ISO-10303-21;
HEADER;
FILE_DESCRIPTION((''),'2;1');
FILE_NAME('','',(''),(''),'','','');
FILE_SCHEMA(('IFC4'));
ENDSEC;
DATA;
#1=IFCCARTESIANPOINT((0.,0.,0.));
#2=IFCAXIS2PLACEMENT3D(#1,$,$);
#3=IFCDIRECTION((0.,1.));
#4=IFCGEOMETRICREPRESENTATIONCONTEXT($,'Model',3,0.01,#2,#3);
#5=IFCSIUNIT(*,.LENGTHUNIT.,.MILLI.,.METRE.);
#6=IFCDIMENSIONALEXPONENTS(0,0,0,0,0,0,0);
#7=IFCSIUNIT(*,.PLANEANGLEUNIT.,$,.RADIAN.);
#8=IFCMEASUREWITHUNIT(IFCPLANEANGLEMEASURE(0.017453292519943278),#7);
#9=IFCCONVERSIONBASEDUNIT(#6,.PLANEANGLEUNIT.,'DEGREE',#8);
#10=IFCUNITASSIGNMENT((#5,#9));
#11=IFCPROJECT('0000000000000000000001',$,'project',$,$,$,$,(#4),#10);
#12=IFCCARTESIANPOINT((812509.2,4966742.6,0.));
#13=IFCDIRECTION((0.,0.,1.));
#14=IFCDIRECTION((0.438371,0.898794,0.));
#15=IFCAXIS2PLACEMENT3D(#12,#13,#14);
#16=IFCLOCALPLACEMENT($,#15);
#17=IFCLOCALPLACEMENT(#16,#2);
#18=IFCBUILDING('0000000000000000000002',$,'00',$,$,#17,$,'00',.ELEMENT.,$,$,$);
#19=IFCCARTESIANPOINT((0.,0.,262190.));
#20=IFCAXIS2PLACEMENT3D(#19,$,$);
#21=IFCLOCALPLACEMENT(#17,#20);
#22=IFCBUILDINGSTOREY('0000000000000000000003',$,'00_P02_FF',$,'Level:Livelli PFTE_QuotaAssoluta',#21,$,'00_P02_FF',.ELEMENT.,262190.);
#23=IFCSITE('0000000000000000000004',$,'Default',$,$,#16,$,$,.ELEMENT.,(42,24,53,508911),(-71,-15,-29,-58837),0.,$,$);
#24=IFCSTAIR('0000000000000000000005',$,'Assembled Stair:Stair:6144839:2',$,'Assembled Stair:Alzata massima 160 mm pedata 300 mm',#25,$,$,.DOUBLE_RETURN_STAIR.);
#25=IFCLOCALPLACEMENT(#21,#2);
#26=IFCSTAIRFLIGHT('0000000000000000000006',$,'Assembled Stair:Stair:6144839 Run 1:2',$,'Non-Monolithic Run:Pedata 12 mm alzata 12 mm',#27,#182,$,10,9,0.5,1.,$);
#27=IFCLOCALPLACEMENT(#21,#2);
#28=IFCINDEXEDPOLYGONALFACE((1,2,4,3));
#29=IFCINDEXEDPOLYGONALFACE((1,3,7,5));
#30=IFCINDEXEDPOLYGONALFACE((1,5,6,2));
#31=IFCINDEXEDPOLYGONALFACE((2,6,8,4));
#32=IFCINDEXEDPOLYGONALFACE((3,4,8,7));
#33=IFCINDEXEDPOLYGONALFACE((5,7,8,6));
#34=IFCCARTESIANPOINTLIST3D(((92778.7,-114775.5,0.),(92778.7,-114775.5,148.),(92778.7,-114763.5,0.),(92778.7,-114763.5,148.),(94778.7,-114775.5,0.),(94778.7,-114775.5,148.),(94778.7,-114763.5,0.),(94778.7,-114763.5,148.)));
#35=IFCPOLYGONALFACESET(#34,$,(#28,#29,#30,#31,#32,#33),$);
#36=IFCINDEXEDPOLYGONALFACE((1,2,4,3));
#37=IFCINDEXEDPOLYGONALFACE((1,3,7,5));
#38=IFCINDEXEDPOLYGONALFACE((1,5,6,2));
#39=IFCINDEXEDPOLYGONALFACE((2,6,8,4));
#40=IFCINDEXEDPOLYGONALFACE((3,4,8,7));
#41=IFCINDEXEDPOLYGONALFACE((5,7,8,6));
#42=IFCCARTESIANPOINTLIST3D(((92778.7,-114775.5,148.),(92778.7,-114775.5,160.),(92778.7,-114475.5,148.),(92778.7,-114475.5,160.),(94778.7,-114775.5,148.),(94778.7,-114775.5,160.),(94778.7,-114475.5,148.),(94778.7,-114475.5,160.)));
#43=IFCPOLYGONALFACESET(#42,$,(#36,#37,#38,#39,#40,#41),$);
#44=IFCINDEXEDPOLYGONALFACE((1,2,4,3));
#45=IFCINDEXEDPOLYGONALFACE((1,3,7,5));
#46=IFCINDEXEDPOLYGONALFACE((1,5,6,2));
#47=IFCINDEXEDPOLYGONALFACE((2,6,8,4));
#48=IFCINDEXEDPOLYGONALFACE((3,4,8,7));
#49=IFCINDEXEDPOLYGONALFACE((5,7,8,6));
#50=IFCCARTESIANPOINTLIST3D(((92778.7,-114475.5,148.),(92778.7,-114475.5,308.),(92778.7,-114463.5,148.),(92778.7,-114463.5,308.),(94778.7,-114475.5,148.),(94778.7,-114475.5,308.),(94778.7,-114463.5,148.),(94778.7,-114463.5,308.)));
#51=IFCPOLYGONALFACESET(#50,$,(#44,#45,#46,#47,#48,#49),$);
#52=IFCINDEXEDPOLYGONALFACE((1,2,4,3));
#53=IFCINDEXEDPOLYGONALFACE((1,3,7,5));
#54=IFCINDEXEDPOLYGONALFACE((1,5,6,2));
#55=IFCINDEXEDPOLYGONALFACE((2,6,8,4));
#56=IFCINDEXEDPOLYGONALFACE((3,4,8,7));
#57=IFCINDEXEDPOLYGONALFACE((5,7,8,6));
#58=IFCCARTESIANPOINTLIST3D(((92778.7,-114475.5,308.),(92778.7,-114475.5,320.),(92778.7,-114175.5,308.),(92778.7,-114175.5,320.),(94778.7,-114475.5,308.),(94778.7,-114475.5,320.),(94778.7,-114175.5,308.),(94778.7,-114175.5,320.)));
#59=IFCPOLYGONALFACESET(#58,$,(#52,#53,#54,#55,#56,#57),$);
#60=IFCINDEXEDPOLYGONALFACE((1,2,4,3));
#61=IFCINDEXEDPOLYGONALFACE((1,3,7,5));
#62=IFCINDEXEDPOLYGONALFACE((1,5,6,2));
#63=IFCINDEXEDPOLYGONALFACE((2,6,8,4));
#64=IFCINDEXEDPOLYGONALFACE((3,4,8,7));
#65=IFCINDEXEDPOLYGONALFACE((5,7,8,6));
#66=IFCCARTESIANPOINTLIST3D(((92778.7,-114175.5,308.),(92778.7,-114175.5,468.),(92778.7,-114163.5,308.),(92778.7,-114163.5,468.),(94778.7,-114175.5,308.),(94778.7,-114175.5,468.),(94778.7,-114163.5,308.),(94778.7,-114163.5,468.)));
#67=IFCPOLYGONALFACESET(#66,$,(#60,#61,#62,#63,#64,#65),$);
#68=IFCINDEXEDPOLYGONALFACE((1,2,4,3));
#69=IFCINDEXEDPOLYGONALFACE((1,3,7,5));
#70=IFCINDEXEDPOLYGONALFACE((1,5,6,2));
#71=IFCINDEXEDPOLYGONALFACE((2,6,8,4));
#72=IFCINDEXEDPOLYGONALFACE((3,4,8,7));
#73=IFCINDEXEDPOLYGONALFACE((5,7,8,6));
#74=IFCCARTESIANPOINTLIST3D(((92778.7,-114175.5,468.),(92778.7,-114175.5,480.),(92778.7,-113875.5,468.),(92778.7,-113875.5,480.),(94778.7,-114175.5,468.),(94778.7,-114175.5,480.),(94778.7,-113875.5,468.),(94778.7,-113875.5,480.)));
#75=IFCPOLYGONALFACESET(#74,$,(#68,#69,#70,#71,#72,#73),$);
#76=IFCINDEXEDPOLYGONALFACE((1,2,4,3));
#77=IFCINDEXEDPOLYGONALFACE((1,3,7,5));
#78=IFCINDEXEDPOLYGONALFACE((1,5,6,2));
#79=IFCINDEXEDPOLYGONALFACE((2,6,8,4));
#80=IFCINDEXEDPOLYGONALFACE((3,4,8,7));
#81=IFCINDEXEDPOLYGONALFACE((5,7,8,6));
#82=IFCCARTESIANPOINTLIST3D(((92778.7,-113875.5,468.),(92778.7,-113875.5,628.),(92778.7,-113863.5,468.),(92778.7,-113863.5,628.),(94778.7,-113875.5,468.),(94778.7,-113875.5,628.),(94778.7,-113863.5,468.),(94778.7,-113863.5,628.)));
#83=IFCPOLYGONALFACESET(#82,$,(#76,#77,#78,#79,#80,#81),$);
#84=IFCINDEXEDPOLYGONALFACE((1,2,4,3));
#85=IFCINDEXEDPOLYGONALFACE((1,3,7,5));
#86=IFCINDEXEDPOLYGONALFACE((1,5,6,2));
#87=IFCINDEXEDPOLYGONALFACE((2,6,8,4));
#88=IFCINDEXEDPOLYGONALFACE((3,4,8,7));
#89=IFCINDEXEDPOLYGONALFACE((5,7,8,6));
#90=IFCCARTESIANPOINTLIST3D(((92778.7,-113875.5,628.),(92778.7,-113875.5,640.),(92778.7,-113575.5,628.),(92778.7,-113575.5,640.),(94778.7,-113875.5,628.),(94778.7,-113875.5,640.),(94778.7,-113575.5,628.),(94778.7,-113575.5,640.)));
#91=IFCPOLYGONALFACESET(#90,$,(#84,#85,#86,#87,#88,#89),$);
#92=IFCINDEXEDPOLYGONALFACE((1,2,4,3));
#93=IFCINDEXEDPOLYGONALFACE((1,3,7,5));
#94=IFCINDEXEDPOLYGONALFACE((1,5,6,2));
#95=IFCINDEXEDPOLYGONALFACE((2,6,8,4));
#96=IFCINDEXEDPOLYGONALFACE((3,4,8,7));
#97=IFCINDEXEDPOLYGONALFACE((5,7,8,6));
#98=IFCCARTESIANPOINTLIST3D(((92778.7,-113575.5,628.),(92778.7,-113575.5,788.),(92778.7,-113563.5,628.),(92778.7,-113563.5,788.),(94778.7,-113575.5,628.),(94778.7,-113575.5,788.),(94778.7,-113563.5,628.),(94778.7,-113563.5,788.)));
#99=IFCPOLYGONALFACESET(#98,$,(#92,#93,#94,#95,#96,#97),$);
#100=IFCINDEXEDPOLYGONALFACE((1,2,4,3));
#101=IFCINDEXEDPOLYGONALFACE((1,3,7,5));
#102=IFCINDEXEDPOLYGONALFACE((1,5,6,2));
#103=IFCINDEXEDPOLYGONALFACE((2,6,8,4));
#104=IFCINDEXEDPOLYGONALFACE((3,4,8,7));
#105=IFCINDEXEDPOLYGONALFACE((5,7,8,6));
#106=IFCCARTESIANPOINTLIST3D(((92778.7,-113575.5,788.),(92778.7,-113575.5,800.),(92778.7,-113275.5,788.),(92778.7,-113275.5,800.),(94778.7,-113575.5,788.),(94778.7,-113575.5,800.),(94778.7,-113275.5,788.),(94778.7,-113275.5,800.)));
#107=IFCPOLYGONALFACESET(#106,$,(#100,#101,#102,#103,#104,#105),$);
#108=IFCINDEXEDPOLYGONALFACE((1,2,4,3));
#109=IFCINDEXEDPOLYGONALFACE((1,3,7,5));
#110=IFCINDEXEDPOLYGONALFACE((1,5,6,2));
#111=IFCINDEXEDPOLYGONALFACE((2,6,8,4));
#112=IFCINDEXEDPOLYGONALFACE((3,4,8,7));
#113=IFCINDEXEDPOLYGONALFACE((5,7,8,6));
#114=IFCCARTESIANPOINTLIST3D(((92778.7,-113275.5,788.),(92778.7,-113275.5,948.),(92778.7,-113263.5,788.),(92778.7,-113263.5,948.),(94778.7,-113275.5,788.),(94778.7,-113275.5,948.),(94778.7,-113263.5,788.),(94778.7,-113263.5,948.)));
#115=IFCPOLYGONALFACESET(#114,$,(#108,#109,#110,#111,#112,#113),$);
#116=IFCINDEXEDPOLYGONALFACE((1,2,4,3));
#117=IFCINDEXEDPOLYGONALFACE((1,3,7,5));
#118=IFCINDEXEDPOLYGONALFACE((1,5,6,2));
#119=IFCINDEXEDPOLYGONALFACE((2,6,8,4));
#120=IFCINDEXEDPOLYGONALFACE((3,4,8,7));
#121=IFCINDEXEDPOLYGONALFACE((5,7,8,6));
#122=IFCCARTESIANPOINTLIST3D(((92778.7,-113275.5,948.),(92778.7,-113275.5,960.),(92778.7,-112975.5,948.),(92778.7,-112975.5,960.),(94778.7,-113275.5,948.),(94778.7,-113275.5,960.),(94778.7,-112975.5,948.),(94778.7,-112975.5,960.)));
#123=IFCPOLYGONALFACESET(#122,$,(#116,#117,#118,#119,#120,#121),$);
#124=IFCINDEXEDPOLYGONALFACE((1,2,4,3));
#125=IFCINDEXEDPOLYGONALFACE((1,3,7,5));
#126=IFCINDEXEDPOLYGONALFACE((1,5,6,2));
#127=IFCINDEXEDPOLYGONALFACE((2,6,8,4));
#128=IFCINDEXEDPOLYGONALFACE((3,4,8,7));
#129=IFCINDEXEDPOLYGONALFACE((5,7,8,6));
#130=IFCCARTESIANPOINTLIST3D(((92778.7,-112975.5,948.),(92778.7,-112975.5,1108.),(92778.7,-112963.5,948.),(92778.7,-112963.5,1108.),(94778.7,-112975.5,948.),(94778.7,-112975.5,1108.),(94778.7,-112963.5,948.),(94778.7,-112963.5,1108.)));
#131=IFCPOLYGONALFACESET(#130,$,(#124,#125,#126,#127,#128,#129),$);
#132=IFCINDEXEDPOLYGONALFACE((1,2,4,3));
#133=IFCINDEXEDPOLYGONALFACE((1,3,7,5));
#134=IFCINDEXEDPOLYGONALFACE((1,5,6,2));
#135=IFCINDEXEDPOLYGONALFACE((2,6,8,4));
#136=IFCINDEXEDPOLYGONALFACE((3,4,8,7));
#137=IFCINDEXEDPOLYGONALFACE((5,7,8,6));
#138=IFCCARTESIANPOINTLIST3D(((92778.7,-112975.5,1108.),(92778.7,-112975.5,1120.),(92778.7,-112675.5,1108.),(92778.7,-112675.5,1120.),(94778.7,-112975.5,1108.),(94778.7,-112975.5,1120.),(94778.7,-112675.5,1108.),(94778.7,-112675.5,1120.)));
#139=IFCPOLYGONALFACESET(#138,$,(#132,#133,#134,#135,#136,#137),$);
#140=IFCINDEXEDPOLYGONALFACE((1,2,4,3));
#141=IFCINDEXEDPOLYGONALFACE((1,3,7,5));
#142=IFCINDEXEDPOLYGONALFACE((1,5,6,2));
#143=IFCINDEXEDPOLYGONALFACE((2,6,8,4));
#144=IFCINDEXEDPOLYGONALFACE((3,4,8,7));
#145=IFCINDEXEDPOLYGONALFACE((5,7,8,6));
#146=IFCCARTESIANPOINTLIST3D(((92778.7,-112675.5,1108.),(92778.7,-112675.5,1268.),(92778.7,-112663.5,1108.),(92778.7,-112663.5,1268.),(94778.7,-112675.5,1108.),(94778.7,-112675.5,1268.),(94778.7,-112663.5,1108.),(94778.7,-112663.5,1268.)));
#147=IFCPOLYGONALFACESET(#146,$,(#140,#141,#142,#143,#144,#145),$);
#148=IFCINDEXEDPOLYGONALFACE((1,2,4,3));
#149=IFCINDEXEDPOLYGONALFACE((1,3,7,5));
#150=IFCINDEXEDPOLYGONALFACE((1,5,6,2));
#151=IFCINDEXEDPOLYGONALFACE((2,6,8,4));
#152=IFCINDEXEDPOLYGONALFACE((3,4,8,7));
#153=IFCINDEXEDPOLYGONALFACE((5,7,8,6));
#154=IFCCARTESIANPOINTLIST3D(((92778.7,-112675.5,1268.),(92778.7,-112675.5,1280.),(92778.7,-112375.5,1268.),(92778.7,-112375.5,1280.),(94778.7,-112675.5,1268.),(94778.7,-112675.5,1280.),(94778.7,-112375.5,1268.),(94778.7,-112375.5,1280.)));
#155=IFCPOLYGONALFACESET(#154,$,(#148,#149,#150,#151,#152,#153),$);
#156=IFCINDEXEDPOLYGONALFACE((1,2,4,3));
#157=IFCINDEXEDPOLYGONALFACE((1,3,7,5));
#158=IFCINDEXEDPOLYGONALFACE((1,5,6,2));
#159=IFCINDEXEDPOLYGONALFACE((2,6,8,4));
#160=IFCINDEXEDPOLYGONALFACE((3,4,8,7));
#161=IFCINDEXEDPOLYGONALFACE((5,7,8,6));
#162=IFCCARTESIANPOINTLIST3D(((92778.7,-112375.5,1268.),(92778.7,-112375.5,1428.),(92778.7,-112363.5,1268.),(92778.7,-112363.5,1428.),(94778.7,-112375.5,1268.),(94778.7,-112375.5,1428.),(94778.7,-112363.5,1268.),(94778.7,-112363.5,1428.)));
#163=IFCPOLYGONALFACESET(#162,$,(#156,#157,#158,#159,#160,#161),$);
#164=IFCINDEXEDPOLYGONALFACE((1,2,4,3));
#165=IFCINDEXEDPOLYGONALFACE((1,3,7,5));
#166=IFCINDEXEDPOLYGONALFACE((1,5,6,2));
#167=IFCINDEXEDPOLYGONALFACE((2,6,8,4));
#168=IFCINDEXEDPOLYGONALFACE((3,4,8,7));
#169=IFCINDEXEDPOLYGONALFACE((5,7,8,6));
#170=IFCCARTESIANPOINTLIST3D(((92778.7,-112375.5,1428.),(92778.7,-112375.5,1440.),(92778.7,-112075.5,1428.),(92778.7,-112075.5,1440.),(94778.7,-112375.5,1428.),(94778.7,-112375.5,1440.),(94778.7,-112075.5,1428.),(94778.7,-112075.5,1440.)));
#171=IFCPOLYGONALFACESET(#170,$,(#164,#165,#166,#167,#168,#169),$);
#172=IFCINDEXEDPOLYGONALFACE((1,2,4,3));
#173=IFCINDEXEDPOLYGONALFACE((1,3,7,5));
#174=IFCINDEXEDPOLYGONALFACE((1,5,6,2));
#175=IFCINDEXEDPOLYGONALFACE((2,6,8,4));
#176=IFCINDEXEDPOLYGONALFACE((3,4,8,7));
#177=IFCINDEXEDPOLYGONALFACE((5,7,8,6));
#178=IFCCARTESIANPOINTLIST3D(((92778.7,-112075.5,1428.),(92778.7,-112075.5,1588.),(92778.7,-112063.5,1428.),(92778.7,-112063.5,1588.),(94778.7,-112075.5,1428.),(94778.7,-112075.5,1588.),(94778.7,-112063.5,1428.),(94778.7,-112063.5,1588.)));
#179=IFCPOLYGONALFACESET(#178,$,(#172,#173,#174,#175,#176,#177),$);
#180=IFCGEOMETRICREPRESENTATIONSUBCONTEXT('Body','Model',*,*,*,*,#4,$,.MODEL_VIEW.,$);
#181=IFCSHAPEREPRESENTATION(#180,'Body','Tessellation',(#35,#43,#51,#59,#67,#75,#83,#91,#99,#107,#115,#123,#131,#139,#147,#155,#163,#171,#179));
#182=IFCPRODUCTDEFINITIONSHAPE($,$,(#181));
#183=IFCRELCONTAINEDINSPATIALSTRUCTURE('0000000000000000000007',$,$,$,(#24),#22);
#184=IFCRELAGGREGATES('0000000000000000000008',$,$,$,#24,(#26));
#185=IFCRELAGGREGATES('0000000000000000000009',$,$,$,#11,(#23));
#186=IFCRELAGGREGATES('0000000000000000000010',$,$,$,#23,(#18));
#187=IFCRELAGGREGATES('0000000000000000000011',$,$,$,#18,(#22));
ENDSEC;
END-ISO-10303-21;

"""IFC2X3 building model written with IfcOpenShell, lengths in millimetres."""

from ifc_helpers import new_model, entity, si_unit, converted_unit, direction, frame, frame_2d, origin, origin_2d_with_axis, place, context, subcontext, project, spatial, rectangle, extrude, element, aggregate, save


model = new_model("IFC2X3")

# Units and contexts
model_context = context("Model", 3, precision=0.01, world=origin(), true_north=direction((0.0, 1.0)))
body_context = subcontext(model_context, "Body", "Model", "MODEL_VIEW")
ifc_project = project(units=[si_unit("LENGTHUNIT", "METRE", prefix="MILLI"), converted_unit("PLANEANGLEUNIT", "DEGREE", entity("IfcPlaneAngleMeasure", 0.017453292519943278), si_unit("PLANEANGLEUNIT", "RADIAN"), dimensions=[0, 0, 0, 0, 0, 0, 0])], contexts=[model_context])

# Site, building, storey
site_placement = place(None, frame((812509.2, 4966742.6, 0.0), z_axis=(0.0, 0.0, 1.0), x_axis=(0.438371, 0.898794, 0.0)))
site = spatial("IfcSite", under=ifc_project, at=site_placement, Name="Default", CompositionType="ELEMENT", RefLatitude=(42, 24, 53, 508911), RefLongitude=(-71, -15, -29, -58837), RefElevation=0.0)
building_placement = place(site_placement, origin())
building = spatial("IfcBuilding", under=site, at=building_placement, Name="00", LongName="00", CompositionType="ELEMENT")
storey_placement = place(building_placement, frame((0.0, 0.0, 262190.0)))
storey = spatial("IfcBuildingStorey", under=building, at=storey_placement, Name="00_P02_FF", ObjectType="Level:Livelli PFTE_QuotaAssoluta", LongName="00_P02_FF", CompositionType="ELEMENT", Elevation=262190.0)

# Stair
stair_1_placement = place(storey_placement, origin())
stair_1 = element("IfcStair", 1, at=stair_1_placement, inside=storey, Name="Assembled Stair:Stair:6144839:2", ObjectType="Assembled Stair:Alzata massima 160 mm pedata 300 mm", ShapeType="DOUBLE_RETURN_STAIR")

# Stair flight
stair_flight_1_placement = place(stair_1_placement, origin())
stair_flight_1 = element("IfcStairFlight", 2, at=stair_flight_1_placement, Name="Assembled Stair:Stair:6144839 Run 1:2", ObjectType="Non-Monolithic Run:Pedata 12 mm alzata 12 mm", NumberOfRiser=10, NumberOfTreads=9, RiserHeight=0.5, TreadLength=1.0, context=body_context, shape_type="SweptSolid", body=[
    extrude(rectangle(XDim=2000.0, YDim=12.0, at=origin_2d_with_axis()), frame((93778.7, -114769.5, 0.0), z_axis=(0.0, 0.0, 1.0), x_axis=(-1.0, 0.0, 0.0)), (0.0, 0.0, 1.0), 148.0),
    extrude(rectangle(XDim=300.0, YDim=2000.0, at=frame_2d((0.0, 0.0), x_axis=(1.0, 0.0))), frame((93778.7, -114625.5, 148.0), z_axis=(0.0, 0.0, 1.0), x_axis=(0.0, -1.0, 0.0)), (0.0, 0.0, 1.0), 12.0),
    extrude(rectangle(XDim=2000.0, YDim=12.0, at=frame_2d((0.0, 0.0), x_axis=(1.0, 0.0))), frame((93778.7, -114469.5, 148.0), z_axis=(0.0, 0.0, 1.0), x_axis=(-1.0, 0.0, 0.0)), (0.0, 0.0, 1.0), 160.0),
    extrude(rectangle(XDim=300.0, YDim=2000.0, at=frame_2d((0.0, 0.0), x_axis=(1.0, 0.0))), frame((93778.7, -114325.5, 308.0), z_axis=(0.0, 0.0, 1.0), x_axis=(0.0, -1.0, 0.0)), (0.0, 0.0, 1.0), 12.0),
    extrude(rectangle(XDim=2000.0, YDim=12.0, at=frame_2d((0.0, 0.0), x_axis=(1.0, 0.0))), frame((93778.7, -114169.5, 308.0), z_axis=(0.0, 0.0, 1.0), x_axis=(-1.0, 0.0, 0.0)), (0.0, 0.0, 1.0), 160.0),
    extrude(rectangle(XDim=300.0, YDim=2000.0, at=frame_2d((0.0, 0.0), x_axis=(1.0, 0.0))), frame((93778.7, -114025.5, 468.0), z_axis=(0.0, 0.0, 1.0), x_axis=(0.0, -1.0, 0.0)), (0.0, 0.0, 1.0), 12.0),
    extrude(rectangle(XDim=2000.0, YDim=12.0, at=frame_2d((0.0, 0.0), x_axis=(1.0, 0.0))), frame((93778.7, -113869.5, 468.0), z_axis=(0.0, 0.0, 1.0), x_axis=(-1.0, 0.0, 0.0)), (0.0, 0.0, 1.0), 160.0),
    extrude(rectangle(XDim=300.0, YDim=2000.0, at=frame_2d((0.0, 0.0), x_axis=(1.0, 0.0))), frame((93778.7, -113725.5, 628.0), z_axis=(0.0, 0.0, 1.0), x_axis=(0.0, -1.0, 0.0)), (0.0, 0.0, 1.0), 12.0),
    extrude(rectangle(XDim=2000.0, YDim=12.0, at=frame_2d((0.0, 0.0), x_axis=(1.0, 0.0))), frame((93778.7, -113569.5, 628.0), z_axis=(0.0, 0.0, 1.0), x_axis=(-1.0, 0.0, 0.0)), (0.0, 0.0, 1.0), 160.0),
    extrude(rectangle(XDim=300.0, YDim=2000.0, at=frame_2d((0.0, 0.0), x_axis=(1.0, 0.0))), frame((93778.7, -113425.5, 788.0), z_axis=(0.0, 0.0, 1.0), x_axis=(0.0, -1.0, 0.0)), (0.0, 0.0, 1.0), 12.0),
    extrude(rectangle(XDim=2000.0, YDim=12.0, at=frame_2d((0.0, 0.0), x_axis=(1.0, 0.0))), frame((93778.7, -113269.5, 788.0), z_axis=(0.0, 0.0, 1.0), x_axis=(-1.0, 0.0, 0.0)), (0.0, 0.0, 1.0), 160.0),
    extrude(rectangle(XDim=300.0, YDim=2000.0, at=frame_2d((0.0, 0.0), x_axis=(1.0, 0.0))), frame((93778.7, -113125.5, 948.0), z_axis=(0.0, 0.0, 1.0), x_axis=(0.0, -1.0, 0.0)), (0.0, 0.0, 1.0), 12.0),
    extrude(rectangle(XDim=2000.0, YDim=12.0, at=frame_2d((0.0, 0.0), x_axis=(1.0, 0.0))), frame((93778.7, -112969.5, 948.0), z_axis=(0.0, 0.0, 1.0), x_axis=(-1.0, 0.0, 0.0)), (0.0, 0.0, 1.0), 160.0),
    extrude(rectangle(XDim=300.0, YDim=2000.0, at=frame_2d((0.0, 0.0), x_axis=(1.0, 0.0))), frame((93778.7, -112825.5, 1108.0), z_axis=(0.0, 0.0, 1.0), x_axis=(0.0, -1.0, 0.0)), (0.0, 0.0, 1.0), 12.0),
    extrude(rectangle(XDim=2000.0, YDim=12.0, at=frame_2d((0.0, 0.0), x_axis=(1.0, 0.0))), frame((93778.7, -112669.5, 1108.0), z_axis=(0.0, 0.0, 1.0), x_axis=(-1.0, 0.0, 0.0)), (0.0, 0.0, 1.0), 160.0),
    extrude(rectangle(XDim=300.0, YDim=2000.0, at=frame_2d((0.0, 0.0), x_axis=(1.0, 0.0))), frame((93778.7, -112525.5, 1268.0), z_axis=(0.0, 0.0, 1.0), x_axis=(0.0, -1.0, 0.0)), (0.0, 0.0, 1.0), 12.0),
    extrude(rectangle(XDim=2000.0, YDim=12.0, at=frame_2d((0.0, 0.0), x_axis=(1.0, 0.0))), frame((93778.7, -112369.5, 1268.0), z_axis=(0.0, 0.0, 1.0), x_axis=(-1.0, 0.0, 0.0)), (0.0, 0.0, 1.0), 160.0),
    extrude(rectangle(XDim=300.0, YDim=2000.0, at=frame_2d((0.0, 0.0), x_axis=(1.0, 0.0))), frame((93778.7, -112225.5, 1428.0), z_axis=(0.0, 0.0, 1.0), x_axis=(0.0, -1.0, 0.0)), (0.0, 0.0, 1.0), 12.0),
    extrude(rectangle(XDim=2000.0, YDim=12.0, at=origin_2d_with_axis()), frame((93778.7, -112069.5, 1428.0), z_axis=(0.0, 0.0, 1.0), x_axis=(-1.0, 0.0, 0.0)), (0.0, 0.0, 1.0), 160.0),
])
aggregate(stair_1, [stair_flight_1])

save(model, "model.ifc")
